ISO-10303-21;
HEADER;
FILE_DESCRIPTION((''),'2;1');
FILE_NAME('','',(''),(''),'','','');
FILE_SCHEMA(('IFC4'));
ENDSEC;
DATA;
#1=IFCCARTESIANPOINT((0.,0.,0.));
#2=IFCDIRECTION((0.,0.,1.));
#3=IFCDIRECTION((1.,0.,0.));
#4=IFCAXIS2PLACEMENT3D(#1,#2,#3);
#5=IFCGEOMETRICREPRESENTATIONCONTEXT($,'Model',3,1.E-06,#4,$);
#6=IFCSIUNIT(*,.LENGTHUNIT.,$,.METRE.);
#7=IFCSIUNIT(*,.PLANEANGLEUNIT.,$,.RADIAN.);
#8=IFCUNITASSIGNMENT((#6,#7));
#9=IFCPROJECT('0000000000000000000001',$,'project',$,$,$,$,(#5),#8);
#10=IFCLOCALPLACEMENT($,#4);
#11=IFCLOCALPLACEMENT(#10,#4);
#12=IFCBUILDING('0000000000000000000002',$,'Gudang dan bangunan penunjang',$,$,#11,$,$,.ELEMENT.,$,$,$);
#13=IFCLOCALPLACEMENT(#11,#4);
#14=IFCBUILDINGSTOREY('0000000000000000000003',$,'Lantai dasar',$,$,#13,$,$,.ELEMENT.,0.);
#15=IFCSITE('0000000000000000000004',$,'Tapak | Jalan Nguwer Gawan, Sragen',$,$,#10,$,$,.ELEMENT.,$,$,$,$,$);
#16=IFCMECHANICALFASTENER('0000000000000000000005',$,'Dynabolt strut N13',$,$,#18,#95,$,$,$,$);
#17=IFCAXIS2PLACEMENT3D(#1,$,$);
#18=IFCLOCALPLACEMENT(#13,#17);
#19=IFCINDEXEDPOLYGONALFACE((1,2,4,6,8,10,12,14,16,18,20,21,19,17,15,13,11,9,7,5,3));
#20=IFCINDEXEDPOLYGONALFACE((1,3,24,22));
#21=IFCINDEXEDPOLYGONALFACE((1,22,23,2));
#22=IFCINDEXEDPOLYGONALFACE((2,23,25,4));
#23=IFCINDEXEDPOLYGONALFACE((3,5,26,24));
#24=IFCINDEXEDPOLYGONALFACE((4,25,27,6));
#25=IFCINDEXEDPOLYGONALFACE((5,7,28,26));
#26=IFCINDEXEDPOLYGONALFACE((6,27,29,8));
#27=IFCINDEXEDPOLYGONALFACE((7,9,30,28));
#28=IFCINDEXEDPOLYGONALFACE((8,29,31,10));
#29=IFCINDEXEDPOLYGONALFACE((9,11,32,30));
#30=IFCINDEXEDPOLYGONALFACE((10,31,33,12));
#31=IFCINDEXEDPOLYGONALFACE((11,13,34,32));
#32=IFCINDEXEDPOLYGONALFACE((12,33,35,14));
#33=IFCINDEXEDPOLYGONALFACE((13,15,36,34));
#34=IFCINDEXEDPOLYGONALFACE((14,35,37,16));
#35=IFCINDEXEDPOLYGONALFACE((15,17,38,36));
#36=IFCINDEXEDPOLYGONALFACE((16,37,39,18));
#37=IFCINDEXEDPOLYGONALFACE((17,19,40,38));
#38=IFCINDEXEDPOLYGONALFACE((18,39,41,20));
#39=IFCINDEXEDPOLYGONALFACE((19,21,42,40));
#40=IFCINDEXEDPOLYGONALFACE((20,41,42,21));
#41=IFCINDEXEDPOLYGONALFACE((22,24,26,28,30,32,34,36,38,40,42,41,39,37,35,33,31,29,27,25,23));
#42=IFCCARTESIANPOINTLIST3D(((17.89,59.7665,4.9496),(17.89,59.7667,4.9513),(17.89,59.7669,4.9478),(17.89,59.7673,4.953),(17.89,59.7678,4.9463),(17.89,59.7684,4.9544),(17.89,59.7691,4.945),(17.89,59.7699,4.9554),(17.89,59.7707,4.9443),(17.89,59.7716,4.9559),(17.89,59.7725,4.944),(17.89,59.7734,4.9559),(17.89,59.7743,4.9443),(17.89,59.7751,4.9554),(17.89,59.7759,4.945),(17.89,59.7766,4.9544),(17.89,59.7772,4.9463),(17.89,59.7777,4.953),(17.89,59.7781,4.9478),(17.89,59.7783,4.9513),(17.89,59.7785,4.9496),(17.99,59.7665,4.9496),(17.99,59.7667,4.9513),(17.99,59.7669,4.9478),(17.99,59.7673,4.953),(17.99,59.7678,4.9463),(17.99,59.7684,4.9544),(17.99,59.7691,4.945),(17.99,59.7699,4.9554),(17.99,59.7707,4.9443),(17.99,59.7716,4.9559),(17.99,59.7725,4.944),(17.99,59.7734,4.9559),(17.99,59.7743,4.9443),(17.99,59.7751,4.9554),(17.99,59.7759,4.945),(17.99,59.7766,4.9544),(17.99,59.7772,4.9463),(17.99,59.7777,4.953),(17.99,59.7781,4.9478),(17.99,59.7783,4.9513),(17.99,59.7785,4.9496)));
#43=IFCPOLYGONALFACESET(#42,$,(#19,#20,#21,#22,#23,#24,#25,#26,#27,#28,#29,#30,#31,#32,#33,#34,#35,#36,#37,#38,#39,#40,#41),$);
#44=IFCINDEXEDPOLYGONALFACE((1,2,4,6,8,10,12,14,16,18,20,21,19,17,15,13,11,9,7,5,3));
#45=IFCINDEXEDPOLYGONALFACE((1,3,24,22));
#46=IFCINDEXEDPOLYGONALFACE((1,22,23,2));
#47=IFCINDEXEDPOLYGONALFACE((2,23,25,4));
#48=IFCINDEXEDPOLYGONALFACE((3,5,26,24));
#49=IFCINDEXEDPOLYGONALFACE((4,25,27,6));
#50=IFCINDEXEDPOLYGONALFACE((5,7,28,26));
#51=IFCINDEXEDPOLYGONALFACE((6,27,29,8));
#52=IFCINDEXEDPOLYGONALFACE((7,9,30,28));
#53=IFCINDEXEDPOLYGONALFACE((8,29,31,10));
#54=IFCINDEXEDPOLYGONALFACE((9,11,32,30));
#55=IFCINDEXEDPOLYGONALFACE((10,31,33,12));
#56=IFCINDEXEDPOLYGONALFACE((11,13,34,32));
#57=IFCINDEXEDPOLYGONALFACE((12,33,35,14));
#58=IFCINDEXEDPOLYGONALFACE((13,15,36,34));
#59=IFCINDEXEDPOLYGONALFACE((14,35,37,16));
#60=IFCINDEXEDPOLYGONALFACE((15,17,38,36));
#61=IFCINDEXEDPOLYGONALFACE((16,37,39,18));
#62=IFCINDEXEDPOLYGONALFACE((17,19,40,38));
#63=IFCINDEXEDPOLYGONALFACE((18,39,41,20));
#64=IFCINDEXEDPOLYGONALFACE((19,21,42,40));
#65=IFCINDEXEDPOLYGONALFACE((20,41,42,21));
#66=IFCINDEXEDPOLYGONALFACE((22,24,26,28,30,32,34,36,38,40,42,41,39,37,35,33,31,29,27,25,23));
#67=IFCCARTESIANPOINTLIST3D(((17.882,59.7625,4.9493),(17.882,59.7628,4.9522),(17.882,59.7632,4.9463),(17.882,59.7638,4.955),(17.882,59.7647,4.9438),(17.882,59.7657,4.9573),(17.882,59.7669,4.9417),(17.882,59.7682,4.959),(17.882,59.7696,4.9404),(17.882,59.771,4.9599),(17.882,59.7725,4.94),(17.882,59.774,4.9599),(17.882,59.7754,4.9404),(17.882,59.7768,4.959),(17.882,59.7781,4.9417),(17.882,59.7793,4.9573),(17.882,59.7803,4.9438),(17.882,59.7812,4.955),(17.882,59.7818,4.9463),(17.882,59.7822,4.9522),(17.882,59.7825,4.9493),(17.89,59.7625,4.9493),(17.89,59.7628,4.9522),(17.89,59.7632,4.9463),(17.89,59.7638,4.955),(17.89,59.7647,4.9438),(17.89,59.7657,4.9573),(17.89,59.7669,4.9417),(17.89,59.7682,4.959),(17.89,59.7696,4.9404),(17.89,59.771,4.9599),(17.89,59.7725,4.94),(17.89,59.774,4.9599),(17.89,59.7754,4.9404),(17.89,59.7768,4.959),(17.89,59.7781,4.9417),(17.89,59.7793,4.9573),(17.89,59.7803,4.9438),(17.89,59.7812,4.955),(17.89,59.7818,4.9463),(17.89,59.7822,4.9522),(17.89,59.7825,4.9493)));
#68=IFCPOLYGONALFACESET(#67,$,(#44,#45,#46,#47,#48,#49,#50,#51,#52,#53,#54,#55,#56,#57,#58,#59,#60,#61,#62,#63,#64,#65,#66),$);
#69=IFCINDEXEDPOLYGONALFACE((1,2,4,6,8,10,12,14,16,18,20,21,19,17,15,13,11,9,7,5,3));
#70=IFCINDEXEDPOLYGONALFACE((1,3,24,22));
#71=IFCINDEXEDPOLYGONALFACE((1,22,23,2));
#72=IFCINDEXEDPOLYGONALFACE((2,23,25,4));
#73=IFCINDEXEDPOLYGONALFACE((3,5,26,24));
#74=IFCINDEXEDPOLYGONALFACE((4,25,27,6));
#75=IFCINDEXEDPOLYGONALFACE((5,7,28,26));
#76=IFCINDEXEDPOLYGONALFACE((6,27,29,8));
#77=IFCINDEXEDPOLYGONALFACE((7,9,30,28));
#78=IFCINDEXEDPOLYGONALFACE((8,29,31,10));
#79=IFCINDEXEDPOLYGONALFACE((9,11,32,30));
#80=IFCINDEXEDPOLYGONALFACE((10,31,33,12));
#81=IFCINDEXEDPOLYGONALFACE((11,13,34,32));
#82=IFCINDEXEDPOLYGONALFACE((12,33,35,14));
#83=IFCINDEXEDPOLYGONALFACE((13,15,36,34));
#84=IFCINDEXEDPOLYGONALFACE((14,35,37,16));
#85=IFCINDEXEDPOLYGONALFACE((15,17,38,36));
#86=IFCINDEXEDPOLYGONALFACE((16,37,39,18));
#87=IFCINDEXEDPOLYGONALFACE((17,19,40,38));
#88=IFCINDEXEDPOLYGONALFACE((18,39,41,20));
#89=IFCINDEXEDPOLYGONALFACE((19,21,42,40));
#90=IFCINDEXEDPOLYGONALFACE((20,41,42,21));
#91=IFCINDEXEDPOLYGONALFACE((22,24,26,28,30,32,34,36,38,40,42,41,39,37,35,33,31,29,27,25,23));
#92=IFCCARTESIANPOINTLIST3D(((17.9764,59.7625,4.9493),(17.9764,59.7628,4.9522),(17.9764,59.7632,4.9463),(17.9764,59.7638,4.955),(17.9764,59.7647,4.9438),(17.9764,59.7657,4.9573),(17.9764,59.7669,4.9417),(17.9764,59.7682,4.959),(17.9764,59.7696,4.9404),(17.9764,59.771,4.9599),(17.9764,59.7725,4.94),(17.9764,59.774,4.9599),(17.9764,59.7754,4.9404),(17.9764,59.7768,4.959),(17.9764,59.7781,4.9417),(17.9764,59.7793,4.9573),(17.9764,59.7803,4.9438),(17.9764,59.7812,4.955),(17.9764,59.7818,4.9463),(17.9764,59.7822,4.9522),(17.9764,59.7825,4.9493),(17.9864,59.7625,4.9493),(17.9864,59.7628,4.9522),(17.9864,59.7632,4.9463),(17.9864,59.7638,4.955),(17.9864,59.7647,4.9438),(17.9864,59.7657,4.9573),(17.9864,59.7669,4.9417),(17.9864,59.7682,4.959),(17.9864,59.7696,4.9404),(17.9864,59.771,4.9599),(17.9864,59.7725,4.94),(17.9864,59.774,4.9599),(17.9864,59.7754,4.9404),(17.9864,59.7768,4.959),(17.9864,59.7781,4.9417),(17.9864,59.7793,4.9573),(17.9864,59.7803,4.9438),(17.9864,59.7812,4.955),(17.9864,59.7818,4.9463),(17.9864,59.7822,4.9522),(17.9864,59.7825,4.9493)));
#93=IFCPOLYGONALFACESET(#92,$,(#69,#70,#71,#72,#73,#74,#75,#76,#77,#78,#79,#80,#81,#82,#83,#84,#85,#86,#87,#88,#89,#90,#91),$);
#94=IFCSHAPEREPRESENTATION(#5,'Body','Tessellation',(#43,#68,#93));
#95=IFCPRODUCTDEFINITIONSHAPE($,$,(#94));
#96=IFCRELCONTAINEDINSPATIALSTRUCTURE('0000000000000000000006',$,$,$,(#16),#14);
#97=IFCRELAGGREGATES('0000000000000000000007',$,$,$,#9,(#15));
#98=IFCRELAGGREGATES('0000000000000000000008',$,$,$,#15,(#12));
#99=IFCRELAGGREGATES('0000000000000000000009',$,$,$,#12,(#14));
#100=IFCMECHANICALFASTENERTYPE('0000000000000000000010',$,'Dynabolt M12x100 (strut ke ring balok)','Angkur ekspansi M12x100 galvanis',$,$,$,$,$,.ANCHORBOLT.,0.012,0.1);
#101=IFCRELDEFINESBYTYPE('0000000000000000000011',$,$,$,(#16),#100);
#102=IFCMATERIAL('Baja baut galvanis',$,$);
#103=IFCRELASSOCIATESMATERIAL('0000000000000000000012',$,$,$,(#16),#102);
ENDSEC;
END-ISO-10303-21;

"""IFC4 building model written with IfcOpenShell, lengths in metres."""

from ifc_helpers import new_model, si_unit, frame, origin_with_axes, place, context, project, spatial, circle, extrude, source, transform, mapped, material, type_object, type_shapes, element, save


model = new_model("IFC4")

# Units and contexts
model_context = context("Model", 3, precision=1e-06, world=origin_with_axes())
ifc_project = project(units=[si_unit("LENGTHUNIT", "METRE"), si_unit("PLANEANGLEUNIT", "RADIAN")], contexts=[model_context])

# Site, building, storey
site_placement = place(None, origin_with_axes())
site = spatial("IfcSite", under=ifc_project, at=site_placement, Name="Tapak | Jalan Nguwer Gawan, Sragen", CompositionType="ELEMENT")
building_placement = place(site_placement, origin_with_axes())
building = spatial("IfcBuilding", under=site, at=building_placement, Name="Gudang dan bangunan penunjang", CompositionType="ELEMENT")
storey_placement = place(building_placement, origin_with_axes())
storey = spatial("IfcBuildingStorey", under=building, at=storey_placement, Name="Lantai dasar", CompositionType="ELEMENT", Elevation=0.0)

# Mechanical fastener
ifc_material = material(Name="Baja baut galvanis")
mechanical_fastener_type = type_object("IfcMechanicalFastenerType", Name="Dynabolt M12x100 (strut ke ring balok)", Description="Angkur ekspansi M12x100 galvanis", NominalDiameter=0.012, NominalLength=0.1, PredefinedType="ANCHORBOLT")
shared_shape = source(origin_with_axes(), model_context, "Body", "SweptSolid", [
    extrude(circle(Radius=0.006), origin_with_axes(), (0.0, 0.0, 1.0), 0.1),
    extrude(circle(Radius=0.01), frame((0.0, 0.0, -0.008), z_axis=(0.0, 0.0, 1.0), x_axis=(1.0, 0.0, 0.0)), (0.0, 0.0, 1.0), 0.008),
    extrude(circle(Radius=0.01), frame((0.0, 0.0, 0.0864), z_axis=(0.0, 0.0, 1.0), x_axis=(1.0, 0.0, 0.0)), (0.0, 0.0, 1.0), 0.01),
])
type_shapes(mechanical_fastener_type, [shared_shape])
placement = place(None, origin_with_axes())
element("IfcMechanicalFastener", 1, at=placement, inside=storey, type_object=mechanical_fastener_type, material=ifc_material, Name="Dynabolt strut N13", context=model_context, shape_type="MappedRepresentation", body=[
    mapped(shared_shape, transform((17.89, 59.7725, 4.95), x_axis=(0.0, 0.0, -1.0), y_axis=(0.0, 1.0, 0.0), z_axis=(1.0, 0.0, 0.0), scale=1.0)),
])

save(model, "model.ifc")
